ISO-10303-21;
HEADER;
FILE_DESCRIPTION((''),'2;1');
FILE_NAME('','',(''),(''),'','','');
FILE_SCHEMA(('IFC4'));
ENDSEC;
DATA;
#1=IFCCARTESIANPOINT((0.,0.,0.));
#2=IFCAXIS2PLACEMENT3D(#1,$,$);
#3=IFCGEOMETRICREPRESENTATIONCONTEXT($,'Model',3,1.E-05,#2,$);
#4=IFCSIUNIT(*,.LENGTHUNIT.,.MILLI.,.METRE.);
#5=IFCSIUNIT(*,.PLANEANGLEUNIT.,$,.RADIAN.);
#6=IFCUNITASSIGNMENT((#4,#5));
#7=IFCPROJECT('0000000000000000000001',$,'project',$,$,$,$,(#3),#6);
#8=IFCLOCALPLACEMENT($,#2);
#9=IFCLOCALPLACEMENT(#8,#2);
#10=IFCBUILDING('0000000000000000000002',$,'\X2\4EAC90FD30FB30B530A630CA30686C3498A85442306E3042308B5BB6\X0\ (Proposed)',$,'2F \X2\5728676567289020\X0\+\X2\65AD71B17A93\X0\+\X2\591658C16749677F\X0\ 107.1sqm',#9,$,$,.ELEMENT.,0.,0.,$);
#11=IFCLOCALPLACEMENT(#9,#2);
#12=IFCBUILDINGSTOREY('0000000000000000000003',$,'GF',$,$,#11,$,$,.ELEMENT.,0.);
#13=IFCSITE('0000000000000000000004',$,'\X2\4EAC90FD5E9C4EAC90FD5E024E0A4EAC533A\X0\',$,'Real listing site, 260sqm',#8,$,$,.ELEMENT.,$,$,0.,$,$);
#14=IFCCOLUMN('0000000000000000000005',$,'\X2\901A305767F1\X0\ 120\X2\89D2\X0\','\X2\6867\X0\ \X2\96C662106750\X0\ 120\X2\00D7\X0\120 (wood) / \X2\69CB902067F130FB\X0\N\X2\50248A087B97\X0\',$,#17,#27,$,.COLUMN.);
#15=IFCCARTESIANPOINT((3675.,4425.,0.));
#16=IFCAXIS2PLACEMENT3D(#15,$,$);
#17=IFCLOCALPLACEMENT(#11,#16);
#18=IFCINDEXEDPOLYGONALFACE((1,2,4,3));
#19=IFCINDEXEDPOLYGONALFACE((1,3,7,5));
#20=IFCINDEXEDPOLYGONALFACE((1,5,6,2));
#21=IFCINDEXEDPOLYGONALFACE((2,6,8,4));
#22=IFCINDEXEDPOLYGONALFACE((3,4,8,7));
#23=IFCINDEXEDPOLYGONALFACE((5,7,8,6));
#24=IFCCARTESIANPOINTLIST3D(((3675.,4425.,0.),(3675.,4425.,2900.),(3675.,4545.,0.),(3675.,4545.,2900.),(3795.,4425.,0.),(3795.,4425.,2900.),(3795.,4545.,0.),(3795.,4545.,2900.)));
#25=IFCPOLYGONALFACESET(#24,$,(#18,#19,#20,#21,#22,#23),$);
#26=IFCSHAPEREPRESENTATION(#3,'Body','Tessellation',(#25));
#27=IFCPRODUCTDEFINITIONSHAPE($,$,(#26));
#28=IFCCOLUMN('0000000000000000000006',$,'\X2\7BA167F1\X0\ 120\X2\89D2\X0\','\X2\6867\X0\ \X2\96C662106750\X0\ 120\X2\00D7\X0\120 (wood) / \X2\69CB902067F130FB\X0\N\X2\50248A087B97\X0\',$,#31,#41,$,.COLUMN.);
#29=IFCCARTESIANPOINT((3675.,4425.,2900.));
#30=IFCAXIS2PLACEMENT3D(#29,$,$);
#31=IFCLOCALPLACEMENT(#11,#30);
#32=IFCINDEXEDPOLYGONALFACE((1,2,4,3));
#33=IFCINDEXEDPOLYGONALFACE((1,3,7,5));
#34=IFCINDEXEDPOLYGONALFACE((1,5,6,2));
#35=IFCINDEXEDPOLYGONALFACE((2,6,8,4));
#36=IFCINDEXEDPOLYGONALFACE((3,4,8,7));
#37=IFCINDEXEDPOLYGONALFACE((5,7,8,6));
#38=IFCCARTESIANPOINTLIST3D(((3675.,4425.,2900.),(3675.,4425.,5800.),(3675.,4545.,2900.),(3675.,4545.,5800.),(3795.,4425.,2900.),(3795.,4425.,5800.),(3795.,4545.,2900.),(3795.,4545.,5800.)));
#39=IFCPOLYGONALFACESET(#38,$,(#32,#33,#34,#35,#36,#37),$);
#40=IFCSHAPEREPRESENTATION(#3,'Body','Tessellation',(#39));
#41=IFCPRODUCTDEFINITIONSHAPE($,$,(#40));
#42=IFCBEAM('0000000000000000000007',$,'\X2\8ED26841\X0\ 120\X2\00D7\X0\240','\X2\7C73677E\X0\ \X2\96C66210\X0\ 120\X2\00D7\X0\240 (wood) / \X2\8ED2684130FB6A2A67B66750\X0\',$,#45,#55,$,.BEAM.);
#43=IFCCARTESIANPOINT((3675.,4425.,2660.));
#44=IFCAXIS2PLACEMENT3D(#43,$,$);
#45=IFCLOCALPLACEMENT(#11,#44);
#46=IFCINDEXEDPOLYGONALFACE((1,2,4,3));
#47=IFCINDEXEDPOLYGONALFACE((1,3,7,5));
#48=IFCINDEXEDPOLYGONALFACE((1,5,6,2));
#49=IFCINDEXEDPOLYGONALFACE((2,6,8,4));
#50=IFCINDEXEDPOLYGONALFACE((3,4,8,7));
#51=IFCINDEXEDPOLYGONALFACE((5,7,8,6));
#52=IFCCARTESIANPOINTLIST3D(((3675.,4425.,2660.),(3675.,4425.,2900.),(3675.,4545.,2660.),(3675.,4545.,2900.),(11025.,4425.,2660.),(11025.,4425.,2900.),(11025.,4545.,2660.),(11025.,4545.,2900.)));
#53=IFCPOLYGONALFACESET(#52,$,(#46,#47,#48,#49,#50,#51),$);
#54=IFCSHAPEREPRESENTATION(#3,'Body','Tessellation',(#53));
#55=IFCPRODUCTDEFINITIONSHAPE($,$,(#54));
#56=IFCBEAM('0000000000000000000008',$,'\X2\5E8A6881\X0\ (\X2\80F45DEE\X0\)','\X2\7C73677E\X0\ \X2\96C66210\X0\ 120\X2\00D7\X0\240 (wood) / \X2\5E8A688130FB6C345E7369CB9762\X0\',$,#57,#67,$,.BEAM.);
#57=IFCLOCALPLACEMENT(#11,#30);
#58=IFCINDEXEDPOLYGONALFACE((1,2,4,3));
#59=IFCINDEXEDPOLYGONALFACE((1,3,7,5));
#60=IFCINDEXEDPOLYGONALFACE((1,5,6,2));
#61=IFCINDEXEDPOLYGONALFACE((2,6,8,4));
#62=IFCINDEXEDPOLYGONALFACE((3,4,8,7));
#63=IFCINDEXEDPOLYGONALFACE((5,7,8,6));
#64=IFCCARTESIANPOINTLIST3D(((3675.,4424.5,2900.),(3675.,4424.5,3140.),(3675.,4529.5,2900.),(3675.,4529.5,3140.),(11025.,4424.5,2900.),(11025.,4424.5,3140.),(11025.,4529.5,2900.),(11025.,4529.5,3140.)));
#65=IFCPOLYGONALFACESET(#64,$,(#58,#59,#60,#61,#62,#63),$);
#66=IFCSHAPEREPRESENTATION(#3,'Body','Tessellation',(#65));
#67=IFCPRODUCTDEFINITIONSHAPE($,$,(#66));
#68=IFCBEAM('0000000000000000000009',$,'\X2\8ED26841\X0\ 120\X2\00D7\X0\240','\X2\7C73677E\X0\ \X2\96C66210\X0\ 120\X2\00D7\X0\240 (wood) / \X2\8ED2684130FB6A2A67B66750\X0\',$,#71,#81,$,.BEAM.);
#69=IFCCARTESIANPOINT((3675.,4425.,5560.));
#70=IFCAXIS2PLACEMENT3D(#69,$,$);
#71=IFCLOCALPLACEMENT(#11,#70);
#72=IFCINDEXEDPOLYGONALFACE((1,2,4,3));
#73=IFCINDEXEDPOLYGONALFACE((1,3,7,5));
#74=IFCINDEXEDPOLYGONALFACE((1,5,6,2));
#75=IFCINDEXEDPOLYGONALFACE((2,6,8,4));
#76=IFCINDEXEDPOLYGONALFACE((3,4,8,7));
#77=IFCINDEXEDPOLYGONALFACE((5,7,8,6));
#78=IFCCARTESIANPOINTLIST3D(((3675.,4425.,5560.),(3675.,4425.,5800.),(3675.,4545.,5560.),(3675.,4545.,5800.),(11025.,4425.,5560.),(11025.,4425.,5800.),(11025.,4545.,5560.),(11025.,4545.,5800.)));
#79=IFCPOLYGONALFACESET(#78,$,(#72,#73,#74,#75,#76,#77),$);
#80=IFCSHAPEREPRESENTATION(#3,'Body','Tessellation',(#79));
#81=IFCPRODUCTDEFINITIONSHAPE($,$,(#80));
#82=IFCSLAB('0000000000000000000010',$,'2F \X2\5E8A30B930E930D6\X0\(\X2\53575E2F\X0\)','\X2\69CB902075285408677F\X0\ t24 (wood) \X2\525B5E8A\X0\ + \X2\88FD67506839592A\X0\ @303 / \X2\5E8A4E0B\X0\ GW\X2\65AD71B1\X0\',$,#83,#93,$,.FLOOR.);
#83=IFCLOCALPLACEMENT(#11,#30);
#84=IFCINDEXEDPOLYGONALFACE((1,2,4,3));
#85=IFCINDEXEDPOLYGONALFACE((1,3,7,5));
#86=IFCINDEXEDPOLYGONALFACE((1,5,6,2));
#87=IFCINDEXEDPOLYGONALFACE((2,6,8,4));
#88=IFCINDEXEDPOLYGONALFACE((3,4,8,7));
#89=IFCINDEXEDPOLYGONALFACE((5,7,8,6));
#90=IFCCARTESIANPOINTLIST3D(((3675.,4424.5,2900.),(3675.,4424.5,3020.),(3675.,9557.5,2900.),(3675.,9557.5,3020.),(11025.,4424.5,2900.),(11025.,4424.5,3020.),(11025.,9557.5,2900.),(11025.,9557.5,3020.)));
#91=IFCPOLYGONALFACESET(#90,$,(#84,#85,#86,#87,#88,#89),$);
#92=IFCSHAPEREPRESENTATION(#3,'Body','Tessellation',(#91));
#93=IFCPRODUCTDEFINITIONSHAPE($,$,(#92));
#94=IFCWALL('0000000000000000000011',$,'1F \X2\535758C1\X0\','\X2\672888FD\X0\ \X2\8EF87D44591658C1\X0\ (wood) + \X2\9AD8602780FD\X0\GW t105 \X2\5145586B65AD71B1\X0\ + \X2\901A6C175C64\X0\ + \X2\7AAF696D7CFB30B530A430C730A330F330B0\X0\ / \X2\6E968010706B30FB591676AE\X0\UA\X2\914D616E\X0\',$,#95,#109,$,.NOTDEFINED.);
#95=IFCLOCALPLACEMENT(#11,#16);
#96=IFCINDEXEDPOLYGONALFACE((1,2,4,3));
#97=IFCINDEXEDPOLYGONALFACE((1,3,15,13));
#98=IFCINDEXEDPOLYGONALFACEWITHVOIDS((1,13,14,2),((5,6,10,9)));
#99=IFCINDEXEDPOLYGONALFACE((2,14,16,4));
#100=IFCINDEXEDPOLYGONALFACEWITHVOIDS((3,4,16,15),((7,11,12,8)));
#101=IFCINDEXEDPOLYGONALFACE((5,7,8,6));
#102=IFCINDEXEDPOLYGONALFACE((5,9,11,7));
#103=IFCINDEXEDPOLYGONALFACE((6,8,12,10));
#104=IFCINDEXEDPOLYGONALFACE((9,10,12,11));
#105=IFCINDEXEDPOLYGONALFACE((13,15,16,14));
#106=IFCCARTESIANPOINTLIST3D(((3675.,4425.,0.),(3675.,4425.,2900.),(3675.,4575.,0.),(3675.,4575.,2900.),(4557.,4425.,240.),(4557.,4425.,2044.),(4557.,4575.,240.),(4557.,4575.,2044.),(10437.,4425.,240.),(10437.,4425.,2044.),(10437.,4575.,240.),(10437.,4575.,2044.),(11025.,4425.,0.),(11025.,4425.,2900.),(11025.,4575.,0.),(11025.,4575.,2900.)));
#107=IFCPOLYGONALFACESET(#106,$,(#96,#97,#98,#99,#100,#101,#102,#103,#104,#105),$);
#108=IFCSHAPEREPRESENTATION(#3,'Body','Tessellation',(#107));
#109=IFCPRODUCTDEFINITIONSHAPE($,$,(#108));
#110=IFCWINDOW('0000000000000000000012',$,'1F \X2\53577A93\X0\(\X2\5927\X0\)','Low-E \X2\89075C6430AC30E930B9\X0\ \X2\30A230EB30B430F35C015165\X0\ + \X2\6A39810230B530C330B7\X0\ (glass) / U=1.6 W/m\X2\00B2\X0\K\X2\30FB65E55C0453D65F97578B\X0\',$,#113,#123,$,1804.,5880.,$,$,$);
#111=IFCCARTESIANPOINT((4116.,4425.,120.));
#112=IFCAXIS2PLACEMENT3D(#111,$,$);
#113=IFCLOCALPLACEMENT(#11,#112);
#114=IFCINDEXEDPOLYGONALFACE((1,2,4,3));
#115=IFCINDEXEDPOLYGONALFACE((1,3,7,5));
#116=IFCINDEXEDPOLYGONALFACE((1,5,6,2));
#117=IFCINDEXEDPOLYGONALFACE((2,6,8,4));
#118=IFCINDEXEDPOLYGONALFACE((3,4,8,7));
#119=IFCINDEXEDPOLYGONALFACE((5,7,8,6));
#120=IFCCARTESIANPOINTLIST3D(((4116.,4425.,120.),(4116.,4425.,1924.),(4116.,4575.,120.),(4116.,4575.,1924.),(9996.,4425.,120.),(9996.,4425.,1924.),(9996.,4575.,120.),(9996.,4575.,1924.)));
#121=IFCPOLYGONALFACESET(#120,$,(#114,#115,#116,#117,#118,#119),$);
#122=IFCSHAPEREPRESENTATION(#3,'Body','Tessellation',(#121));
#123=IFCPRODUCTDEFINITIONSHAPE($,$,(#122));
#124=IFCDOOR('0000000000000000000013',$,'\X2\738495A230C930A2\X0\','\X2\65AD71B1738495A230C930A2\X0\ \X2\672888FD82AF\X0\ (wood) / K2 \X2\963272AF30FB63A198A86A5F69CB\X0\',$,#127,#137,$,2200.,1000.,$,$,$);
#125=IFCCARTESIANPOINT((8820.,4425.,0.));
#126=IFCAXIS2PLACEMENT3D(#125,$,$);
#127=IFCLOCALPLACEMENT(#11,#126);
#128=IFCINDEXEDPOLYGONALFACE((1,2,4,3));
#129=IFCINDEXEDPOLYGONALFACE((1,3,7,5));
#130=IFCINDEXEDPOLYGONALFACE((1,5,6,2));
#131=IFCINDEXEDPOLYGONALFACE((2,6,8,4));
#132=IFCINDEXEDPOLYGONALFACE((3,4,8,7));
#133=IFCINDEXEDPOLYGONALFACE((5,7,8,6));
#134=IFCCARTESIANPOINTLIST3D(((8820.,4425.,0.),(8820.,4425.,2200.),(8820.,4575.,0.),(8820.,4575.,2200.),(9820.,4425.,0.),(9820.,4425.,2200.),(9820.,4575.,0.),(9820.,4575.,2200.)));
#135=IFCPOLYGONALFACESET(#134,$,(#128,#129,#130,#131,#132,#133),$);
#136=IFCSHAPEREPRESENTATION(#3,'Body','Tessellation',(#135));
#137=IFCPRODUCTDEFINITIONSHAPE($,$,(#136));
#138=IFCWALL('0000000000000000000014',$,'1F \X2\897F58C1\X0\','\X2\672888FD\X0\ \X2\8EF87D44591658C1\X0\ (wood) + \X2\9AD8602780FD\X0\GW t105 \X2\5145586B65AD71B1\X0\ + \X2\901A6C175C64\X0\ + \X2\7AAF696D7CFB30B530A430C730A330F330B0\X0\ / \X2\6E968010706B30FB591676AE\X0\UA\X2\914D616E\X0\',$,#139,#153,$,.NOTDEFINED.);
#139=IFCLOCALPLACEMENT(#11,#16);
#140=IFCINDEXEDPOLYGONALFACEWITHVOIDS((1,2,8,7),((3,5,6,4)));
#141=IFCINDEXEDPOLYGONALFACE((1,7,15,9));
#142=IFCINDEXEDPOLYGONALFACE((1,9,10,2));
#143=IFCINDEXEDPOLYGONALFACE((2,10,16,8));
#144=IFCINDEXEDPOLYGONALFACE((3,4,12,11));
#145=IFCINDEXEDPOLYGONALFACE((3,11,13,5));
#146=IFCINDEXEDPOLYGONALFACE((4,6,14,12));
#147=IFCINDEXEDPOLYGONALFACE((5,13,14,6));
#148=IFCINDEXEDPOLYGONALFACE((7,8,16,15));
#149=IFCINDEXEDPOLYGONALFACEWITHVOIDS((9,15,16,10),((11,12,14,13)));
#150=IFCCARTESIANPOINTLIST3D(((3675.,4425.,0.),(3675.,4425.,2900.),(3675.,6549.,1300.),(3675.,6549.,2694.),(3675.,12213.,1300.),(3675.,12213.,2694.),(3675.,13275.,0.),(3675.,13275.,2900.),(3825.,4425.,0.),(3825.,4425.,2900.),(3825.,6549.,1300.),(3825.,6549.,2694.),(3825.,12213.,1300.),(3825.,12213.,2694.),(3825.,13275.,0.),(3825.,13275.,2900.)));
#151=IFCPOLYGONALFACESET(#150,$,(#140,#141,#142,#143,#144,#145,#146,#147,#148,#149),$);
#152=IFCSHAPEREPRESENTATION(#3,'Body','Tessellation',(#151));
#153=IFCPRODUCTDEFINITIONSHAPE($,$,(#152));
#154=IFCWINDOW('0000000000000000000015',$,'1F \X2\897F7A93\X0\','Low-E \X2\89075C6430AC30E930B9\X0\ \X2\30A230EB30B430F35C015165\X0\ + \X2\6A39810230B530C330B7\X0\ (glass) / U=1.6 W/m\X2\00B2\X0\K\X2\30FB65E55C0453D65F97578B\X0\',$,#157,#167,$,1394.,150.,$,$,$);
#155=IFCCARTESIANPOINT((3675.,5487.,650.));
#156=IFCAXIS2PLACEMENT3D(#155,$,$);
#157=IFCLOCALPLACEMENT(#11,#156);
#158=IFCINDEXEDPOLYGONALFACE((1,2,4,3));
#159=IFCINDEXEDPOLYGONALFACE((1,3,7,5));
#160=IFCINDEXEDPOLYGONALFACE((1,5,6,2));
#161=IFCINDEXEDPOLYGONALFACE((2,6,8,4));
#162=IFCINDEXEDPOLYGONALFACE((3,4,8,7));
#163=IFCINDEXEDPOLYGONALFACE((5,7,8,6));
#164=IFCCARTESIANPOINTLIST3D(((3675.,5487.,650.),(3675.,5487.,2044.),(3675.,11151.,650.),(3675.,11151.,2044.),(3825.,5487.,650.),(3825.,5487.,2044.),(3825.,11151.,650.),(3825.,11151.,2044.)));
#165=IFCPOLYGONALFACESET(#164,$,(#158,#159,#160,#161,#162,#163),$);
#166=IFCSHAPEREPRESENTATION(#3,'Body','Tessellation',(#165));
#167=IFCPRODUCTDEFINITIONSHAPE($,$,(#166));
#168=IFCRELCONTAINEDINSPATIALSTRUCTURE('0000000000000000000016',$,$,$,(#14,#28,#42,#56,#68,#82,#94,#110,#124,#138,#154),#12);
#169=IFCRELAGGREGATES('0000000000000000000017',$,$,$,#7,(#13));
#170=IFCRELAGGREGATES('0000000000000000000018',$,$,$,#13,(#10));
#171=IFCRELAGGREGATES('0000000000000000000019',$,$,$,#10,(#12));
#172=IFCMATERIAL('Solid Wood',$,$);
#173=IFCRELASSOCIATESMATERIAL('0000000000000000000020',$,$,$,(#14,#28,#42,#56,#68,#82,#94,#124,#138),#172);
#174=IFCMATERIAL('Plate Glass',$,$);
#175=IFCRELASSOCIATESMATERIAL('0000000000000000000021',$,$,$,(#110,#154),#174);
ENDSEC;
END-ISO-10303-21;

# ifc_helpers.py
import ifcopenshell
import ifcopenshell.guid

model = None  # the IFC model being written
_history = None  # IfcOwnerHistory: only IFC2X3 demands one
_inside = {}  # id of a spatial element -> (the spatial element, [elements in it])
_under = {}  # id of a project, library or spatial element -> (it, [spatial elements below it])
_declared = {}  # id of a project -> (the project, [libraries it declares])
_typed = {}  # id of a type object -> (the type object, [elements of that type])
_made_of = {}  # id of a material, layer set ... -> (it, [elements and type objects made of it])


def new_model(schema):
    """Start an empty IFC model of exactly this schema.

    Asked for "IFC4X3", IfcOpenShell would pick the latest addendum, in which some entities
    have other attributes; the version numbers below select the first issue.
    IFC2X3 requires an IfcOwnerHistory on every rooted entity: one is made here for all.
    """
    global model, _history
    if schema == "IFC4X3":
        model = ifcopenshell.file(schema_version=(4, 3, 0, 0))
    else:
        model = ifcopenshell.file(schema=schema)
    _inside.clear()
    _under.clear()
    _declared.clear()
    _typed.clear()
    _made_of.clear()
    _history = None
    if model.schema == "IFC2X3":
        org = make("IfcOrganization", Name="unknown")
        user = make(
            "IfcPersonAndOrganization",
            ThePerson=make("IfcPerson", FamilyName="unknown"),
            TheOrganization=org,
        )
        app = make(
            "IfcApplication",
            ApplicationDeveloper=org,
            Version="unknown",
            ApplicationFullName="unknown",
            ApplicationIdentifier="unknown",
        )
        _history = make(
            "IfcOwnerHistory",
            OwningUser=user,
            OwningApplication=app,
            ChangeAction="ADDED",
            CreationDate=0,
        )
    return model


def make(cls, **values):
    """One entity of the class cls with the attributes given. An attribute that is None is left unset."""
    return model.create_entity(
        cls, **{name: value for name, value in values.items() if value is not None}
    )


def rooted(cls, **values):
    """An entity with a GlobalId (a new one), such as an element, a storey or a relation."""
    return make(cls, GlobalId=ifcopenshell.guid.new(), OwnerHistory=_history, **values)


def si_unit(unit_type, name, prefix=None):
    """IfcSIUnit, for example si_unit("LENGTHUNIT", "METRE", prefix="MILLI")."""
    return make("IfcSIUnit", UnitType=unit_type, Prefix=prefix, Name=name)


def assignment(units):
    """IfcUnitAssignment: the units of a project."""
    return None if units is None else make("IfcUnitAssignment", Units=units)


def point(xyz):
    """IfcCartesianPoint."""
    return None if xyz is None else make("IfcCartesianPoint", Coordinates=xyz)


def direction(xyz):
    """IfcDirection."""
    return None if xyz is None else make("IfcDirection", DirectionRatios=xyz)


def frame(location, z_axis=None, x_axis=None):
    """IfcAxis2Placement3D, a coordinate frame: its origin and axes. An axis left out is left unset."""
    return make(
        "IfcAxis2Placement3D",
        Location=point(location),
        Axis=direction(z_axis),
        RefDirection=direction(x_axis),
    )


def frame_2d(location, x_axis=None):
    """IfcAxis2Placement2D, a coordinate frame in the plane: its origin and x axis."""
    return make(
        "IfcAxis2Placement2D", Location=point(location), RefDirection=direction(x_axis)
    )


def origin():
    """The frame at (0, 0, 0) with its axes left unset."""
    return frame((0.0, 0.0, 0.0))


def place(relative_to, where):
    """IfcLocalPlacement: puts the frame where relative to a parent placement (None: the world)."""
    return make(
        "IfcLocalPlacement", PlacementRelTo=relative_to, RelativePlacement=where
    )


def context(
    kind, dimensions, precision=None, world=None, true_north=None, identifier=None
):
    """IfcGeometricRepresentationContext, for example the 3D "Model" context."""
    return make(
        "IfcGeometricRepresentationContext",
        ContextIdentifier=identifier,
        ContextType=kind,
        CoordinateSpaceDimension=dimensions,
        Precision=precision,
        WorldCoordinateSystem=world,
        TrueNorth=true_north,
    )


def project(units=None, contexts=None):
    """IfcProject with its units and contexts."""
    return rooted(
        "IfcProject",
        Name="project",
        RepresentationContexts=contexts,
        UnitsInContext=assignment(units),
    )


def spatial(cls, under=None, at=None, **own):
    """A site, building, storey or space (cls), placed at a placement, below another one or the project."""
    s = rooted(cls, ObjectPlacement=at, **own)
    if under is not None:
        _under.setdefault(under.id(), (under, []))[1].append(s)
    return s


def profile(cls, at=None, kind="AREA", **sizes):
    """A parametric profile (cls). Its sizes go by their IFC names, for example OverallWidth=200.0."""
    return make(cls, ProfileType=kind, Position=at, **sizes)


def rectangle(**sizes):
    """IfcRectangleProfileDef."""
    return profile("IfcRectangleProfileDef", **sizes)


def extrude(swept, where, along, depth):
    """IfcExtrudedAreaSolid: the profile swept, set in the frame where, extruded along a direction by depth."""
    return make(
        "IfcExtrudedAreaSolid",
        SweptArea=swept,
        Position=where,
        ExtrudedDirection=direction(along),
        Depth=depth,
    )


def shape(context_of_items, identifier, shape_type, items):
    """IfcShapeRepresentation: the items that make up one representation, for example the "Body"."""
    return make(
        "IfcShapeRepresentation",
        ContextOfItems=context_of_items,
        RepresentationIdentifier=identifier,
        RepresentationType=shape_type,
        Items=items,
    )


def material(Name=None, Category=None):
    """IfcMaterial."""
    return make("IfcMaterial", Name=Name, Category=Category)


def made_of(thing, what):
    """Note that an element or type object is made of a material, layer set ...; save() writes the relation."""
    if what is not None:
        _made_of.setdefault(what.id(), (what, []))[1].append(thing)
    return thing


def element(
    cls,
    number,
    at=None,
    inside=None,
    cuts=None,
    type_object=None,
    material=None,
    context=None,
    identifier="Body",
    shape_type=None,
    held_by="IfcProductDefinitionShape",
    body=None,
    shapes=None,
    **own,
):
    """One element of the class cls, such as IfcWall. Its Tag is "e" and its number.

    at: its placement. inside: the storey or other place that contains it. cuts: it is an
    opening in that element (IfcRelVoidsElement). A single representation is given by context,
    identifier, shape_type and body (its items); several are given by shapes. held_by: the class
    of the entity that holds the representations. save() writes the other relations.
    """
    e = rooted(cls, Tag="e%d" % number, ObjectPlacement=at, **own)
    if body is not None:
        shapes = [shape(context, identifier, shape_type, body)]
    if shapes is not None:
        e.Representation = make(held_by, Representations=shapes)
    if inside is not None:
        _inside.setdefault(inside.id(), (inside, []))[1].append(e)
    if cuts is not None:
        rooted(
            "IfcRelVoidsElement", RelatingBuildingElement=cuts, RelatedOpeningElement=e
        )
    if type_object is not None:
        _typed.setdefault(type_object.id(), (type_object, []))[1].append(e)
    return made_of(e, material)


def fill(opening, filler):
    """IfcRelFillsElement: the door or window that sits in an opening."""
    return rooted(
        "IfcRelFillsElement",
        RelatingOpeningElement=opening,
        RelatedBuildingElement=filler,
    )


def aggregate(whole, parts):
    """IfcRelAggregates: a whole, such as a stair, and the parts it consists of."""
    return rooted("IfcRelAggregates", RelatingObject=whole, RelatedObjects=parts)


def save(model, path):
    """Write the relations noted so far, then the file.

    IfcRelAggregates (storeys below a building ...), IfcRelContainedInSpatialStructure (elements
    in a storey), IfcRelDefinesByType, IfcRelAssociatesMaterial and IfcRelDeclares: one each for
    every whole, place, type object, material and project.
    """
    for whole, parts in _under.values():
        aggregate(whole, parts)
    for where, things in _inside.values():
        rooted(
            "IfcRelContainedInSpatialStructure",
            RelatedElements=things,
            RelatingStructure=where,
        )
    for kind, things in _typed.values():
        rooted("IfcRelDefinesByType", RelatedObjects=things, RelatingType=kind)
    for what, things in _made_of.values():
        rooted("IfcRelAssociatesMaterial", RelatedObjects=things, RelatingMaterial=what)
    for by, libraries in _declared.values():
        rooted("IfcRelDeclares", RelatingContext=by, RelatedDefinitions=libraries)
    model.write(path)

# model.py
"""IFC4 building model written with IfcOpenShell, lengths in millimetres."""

from ifc_helpers import new_model, si_unit, frame, frame_2d, origin, place, context, project, spatial, rectangle, extrude, material, element, fill, save


model = new_model("IFC4")

# Units and contexts
model_context = context("Model", 3, precision=1e-05, world=origin())
ifc_project = project(units=[si_unit("LENGTHUNIT", "METRE", prefix="MILLI"), si_unit("PLANEANGLEUNIT", "RADIAN")], contexts=[model_context])

# Site, building, storey
site_placement = place(None, origin())
site = spatial("IfcSite", under=ifc_project, at=site_placement, Name="京都府京都市上京区", ObjectType="Real listing site, 260sqm", CompositionType="ELEMENT", RefElevation=0.0)
building_placement = place(site_placement, origin())
building = spatial("IfcBuilding", under=site, at=building_placement, Name="京都・サウナと水風呂のある家 (Proposed)", ObjectType="2F 在来木造+断熱窓+外壁杉板 107.1sqm", CompositionType="ELEMENT", ElevationOfRefHeight=0.0, ElevationOfTerrain=0.0)
storey_placement = place(building_placement, origin())
storey = spatial("IfcBuildingStorey", under=building, at=storey_placement, Name="GF", CompositionType="ELEMENT", Elevation=0.0)

# Columns
ifc_material_1 = material(Name="Solid Wood")
column_1_placement = place(storey_placement, frame((3675.0, 4425.0, 0.0)))
element("IfcColumn", 1, at=column_1_placement, inside=storey, material=ifc_material_1, Name="通し柱 120角", Description="桧 集成材 120×120 (wood) / 構造柱・N値計算", PredefinedType="COLUMN", context=model_context, shape_type="SweptSolid", body=[
    extrude(rectangle(XDim=120.0, YDim=120.0, at=frame_2d((60.0, 60.0))), frame((3675.0, 4425.0, 0.0)), (0.0, 0.0, 1.0), 2900.0),
])
column_2_placement = place(storey_placement, frame((3675.0, 4425.0, 2900.0)))
element("IfcColumn", 2, at=column_2_placement, inside=storey, material=ifc_material_1, Name="管柱 120角", Description="桧 集成材 120×120 (wood) / 構造柱・N値計算", PredefinedType="COLUMN", context=model_context, shape_type="SweptSolid", body=[
    extrude(rectangle(XDim=120.0, YDim=120.0, at=frame_2d((60.0, 60.0))), frame((3675.0, 4425.0, 2900.0)), (0.0, 0.0, 1.0), 2900.0),
])

# Beams
beam_1_placement = place(storey_placement, frame((3675.0, 4425.0, 2660.0)))
element("IfcBeam", 3, at=beam_1_placement, inside=storey, material=ifc_material_1, Name="軒桁 120×240", Description="米松 集成 120×240 (wood) / 軒桁・横架材", PredefinedType="BEAM", context=model_context, shape_type="SweptSolid", body=[
    extrude(rectangle(XDim=7350.0, YDim=120.0, at=frame_2d((3675.0, 60.0))), frame((3675.0, 4425.0, 2660.0)), (0.0, 0.0, 1.0), 240.0),
])
beam_2_placement = place(storey_placement, frame((3675.0, 4425.0, 2900.0)))
element("IfcBeam", 4, at=beam_2_placement, inside=storey, material=ifc_material_1, Name="床梁 (胴差)", Description="米松 集成 120×240 (wood) / 床梁・水平構面", PredefinedType="BEAM", context=model_context, shape_type="SweptSolid", body=[
    extrude(rectangle(XDim=7350.0, YDim=105.0, at=frame_2d((3675.0, 52.0))), frame((3675.0, 4425.0, 2900.0)), (0.0, 0.0, 1.0), 240.0),
])
beam_3_placement = place(storey_placement, frame((3675.0, 4425.0, 5560.0)))
element("IfcBeam", 5, at=beam_3_placement, inside=storey, material=ifc_material_1, Name="軒桁 120×240", Description="米松 集成 120×240 (wood) / 軒桁・横架材", PredefinedType="BEAM", context=model_context, shape_type="SweptSolid", body=[
    extrude(rectangle(XDim=7350.0, YDim=120.0, at=frame_2d((3675.0, 60.0))), frame((3675.0, 4425.0, 5560.0)), (0.0, 0.0, 1.0), 240.0),
])

# Slab
slab_1_placement = place(storey_placement, frame((3675.0, 4425.0, 2900.0)))
element("IfcSlab", 6, at=slab_1_placement, inside=storey, material=ifc_material_1, Name="2F 床スラブ(南帯)", Description="構造用合板 t24 (wood) 剛床 + 製材根太 @303 / 床下 GW断熱", PredefinedType="FLOOR", context=model_context, shape_type="SweptSolid", body=[
    extrude(rectangle(XDim=7350.0, YDim=5133.0, at=frame_2d((3675.0, 2566.0))), frame((3675.0, 4425.0, 2900.0)), (0.0, 0.0, 1.0), 120.0),
])

# Wall, openings, window, door
wall_1_placement = place(storey_placement, frame((3675.0, 4425.0, 0.0)))
wall_1 = element("IfcWall", 7, at=wall_1_placement, inside=storey, material=ifc_material_1, Name="1F 南壁", Description="木製 軸組外壁 (wood) + 高性能GW t105 充填断熱 + 通気層 + 窯業系サイディング / 準耐火・外皮UA配慮", PredefinedType="NOTDEFINED", context=model_context, shape_type="SweptSolid", body=[
    extrude(rectangle(XDim=7350.0, YDim=150.0, at=frame_2d((3675.0, 75.0))), frame((3675.0, 4425.0, 0.0)), (0.0, 0.0, 1.0), 2900.0),
])
opening_1_placement = place(storey_placement, frame((4116.0, 4425.0, 120.0)))
opening_1 = element("IfcOpeningElement", 8, at=opening_1_placement, cuts=wall_1, PredefinedType="NOTDEFINED", context=model_context, shape_type="SweptSolid", body=[
    extrude(rectangle(XDim=5880.0, YDim=150.0, at=frame_2d((2940.0, 75.0))), frame((4116.0, 4425.0, 120.0)), (0.0, 0.0, 1.0), 1804.0),
])
opening_2_placement = place(storey_placement, frame((8820.0, 4425.0, 0.0)))
opening_2 = element("IfcOpeningElement", 9, at=opening_2_placement, cuts=wall_1, PredefinedType="NOTDEFINED", context=model_context, shape_type="SweptSolid", body=[
    extrude(rectangle(XDim=1000.0, YDim=150.0, at=frame_2d((500.0, 75.0))), frame((8820.0, 4425.0, 0.0)), (0.0, 0.0, 1.0), 2200.0),
])
ifc_material_2 = material(Name="Plate Glass")
window_1_placement = place(storey_placement, frame((4116.0, 4425.0, 120.0)))
window_1 = element("IfcWindow", 10, at=window_1_placement, inside=storey, material=ifc_material_2, Name="1F 南窓(大)", Description="Low-E 複層ガラス アルゴン封入 + 樹脂サッシ (glass) / U=1.6 W/m²K・日射取得型", OverallHeight=1804.0, OverallWidth=5880.0, context=model_context, shape_type="SweptSolid", body=[
    extrude(rectangle(XDim=5880.0, YDim=150.0, at=frame_2d((2940.0, 75.0))), frame((4116.0, 4425.0, 120.0)), (0.0, 0.0, 1.0), 1804.0),
])
fill(opening_1, window_1)
door_placement = place(storey_placement, frame((8820.0, 4425.0, 0.0)))
door = element("IfcDoor", 11, at=door_placement, inside=storey, material=ifc_material_1, Name="玄関ドア", Description="断熱玄関ドア 木製芯 (wood) / K2 防犯・採風機構", OverallHeight=2200.0, OverallWidth=1000.0, context=model_context, shape_type="SweptSolid", body=[
    extrude(rectangle(XDim=1000.0, YDim=150.0, at=frame_2d((500.0, 75.0))), frame((8820.0, 4425.0, 0.0)), (0.0, 0.0, 1.0), 2200.0),
])
fill(opening_2, door)

# Wall, opening, window
wall_2_placement = place(storey_placement, frame((3675.0, 4425.0, 0.0)))
wall_2 = element("IfcWall", 12, at=wall_2_placement, inside=storey, material=ifc_material_1, Name="1F 西壁", Description="木製 軸組外壁 (wood) + 高性能GW t105 充填断熱 + 通気層 + 窯業系サイディング / 準耐火・外皮UA配慮", PredefinedType="NOTDEFINED", context=model_context, shape_type="SweptSolid", body=[
    extrude(rectangle(XDim=150.0, YDim=8850.0, at=frame_2d((75.0, 4425.0))), frame((3675.0, 4425.0, 0.0)), (0.0, 0.0, 1.0), 2900.0),
])
opening_3_placement = place(storey_placement, frame((3675.0, 5487.0, 650.0)))
opening_3 = element("IfcOpeningElement", 13, at=opening_3_placement, cuts=wall_2, PredefinedType="NOTDEFINED", context=model_context, shape_type="SweptSolid", body=[
    extrude(rectangle(XDim=150.0, YDim=5664.0, at=frame_2d((75.0, 2832.0))), frame((3675.0, 5487.0, 650.0)), (0.0, 0.0, 1.0), 1394.0),
])
window_2_placement = place(storey_placement, frame((3675.0, 5487.0, 650.0)))
window_2 = element("IfcWindow", 14, at=window_2_placement, inside=storey, material=ifc_material_2, Name="1F 西窓", Description="Low-E 複層ガラス アルゴン封入 + 樹脂サッシ (glass) / U=1.6 W/m²K・日射取得型", OverallHeight=1394.0, OverallWidth=150.0, context=model_context, shape_type="SweptSolid", body=[
    extrude(rectangle(XDim=150.0, YDim=5664.0, at=frame_2d((75.0, 2832.0))), frame((3675.0, 5487.0, 650.0)), (0.0, 0.0, 1.0), 1394.0),
])
fill(opening_3, window_2)

save(model, "model.ifc")
